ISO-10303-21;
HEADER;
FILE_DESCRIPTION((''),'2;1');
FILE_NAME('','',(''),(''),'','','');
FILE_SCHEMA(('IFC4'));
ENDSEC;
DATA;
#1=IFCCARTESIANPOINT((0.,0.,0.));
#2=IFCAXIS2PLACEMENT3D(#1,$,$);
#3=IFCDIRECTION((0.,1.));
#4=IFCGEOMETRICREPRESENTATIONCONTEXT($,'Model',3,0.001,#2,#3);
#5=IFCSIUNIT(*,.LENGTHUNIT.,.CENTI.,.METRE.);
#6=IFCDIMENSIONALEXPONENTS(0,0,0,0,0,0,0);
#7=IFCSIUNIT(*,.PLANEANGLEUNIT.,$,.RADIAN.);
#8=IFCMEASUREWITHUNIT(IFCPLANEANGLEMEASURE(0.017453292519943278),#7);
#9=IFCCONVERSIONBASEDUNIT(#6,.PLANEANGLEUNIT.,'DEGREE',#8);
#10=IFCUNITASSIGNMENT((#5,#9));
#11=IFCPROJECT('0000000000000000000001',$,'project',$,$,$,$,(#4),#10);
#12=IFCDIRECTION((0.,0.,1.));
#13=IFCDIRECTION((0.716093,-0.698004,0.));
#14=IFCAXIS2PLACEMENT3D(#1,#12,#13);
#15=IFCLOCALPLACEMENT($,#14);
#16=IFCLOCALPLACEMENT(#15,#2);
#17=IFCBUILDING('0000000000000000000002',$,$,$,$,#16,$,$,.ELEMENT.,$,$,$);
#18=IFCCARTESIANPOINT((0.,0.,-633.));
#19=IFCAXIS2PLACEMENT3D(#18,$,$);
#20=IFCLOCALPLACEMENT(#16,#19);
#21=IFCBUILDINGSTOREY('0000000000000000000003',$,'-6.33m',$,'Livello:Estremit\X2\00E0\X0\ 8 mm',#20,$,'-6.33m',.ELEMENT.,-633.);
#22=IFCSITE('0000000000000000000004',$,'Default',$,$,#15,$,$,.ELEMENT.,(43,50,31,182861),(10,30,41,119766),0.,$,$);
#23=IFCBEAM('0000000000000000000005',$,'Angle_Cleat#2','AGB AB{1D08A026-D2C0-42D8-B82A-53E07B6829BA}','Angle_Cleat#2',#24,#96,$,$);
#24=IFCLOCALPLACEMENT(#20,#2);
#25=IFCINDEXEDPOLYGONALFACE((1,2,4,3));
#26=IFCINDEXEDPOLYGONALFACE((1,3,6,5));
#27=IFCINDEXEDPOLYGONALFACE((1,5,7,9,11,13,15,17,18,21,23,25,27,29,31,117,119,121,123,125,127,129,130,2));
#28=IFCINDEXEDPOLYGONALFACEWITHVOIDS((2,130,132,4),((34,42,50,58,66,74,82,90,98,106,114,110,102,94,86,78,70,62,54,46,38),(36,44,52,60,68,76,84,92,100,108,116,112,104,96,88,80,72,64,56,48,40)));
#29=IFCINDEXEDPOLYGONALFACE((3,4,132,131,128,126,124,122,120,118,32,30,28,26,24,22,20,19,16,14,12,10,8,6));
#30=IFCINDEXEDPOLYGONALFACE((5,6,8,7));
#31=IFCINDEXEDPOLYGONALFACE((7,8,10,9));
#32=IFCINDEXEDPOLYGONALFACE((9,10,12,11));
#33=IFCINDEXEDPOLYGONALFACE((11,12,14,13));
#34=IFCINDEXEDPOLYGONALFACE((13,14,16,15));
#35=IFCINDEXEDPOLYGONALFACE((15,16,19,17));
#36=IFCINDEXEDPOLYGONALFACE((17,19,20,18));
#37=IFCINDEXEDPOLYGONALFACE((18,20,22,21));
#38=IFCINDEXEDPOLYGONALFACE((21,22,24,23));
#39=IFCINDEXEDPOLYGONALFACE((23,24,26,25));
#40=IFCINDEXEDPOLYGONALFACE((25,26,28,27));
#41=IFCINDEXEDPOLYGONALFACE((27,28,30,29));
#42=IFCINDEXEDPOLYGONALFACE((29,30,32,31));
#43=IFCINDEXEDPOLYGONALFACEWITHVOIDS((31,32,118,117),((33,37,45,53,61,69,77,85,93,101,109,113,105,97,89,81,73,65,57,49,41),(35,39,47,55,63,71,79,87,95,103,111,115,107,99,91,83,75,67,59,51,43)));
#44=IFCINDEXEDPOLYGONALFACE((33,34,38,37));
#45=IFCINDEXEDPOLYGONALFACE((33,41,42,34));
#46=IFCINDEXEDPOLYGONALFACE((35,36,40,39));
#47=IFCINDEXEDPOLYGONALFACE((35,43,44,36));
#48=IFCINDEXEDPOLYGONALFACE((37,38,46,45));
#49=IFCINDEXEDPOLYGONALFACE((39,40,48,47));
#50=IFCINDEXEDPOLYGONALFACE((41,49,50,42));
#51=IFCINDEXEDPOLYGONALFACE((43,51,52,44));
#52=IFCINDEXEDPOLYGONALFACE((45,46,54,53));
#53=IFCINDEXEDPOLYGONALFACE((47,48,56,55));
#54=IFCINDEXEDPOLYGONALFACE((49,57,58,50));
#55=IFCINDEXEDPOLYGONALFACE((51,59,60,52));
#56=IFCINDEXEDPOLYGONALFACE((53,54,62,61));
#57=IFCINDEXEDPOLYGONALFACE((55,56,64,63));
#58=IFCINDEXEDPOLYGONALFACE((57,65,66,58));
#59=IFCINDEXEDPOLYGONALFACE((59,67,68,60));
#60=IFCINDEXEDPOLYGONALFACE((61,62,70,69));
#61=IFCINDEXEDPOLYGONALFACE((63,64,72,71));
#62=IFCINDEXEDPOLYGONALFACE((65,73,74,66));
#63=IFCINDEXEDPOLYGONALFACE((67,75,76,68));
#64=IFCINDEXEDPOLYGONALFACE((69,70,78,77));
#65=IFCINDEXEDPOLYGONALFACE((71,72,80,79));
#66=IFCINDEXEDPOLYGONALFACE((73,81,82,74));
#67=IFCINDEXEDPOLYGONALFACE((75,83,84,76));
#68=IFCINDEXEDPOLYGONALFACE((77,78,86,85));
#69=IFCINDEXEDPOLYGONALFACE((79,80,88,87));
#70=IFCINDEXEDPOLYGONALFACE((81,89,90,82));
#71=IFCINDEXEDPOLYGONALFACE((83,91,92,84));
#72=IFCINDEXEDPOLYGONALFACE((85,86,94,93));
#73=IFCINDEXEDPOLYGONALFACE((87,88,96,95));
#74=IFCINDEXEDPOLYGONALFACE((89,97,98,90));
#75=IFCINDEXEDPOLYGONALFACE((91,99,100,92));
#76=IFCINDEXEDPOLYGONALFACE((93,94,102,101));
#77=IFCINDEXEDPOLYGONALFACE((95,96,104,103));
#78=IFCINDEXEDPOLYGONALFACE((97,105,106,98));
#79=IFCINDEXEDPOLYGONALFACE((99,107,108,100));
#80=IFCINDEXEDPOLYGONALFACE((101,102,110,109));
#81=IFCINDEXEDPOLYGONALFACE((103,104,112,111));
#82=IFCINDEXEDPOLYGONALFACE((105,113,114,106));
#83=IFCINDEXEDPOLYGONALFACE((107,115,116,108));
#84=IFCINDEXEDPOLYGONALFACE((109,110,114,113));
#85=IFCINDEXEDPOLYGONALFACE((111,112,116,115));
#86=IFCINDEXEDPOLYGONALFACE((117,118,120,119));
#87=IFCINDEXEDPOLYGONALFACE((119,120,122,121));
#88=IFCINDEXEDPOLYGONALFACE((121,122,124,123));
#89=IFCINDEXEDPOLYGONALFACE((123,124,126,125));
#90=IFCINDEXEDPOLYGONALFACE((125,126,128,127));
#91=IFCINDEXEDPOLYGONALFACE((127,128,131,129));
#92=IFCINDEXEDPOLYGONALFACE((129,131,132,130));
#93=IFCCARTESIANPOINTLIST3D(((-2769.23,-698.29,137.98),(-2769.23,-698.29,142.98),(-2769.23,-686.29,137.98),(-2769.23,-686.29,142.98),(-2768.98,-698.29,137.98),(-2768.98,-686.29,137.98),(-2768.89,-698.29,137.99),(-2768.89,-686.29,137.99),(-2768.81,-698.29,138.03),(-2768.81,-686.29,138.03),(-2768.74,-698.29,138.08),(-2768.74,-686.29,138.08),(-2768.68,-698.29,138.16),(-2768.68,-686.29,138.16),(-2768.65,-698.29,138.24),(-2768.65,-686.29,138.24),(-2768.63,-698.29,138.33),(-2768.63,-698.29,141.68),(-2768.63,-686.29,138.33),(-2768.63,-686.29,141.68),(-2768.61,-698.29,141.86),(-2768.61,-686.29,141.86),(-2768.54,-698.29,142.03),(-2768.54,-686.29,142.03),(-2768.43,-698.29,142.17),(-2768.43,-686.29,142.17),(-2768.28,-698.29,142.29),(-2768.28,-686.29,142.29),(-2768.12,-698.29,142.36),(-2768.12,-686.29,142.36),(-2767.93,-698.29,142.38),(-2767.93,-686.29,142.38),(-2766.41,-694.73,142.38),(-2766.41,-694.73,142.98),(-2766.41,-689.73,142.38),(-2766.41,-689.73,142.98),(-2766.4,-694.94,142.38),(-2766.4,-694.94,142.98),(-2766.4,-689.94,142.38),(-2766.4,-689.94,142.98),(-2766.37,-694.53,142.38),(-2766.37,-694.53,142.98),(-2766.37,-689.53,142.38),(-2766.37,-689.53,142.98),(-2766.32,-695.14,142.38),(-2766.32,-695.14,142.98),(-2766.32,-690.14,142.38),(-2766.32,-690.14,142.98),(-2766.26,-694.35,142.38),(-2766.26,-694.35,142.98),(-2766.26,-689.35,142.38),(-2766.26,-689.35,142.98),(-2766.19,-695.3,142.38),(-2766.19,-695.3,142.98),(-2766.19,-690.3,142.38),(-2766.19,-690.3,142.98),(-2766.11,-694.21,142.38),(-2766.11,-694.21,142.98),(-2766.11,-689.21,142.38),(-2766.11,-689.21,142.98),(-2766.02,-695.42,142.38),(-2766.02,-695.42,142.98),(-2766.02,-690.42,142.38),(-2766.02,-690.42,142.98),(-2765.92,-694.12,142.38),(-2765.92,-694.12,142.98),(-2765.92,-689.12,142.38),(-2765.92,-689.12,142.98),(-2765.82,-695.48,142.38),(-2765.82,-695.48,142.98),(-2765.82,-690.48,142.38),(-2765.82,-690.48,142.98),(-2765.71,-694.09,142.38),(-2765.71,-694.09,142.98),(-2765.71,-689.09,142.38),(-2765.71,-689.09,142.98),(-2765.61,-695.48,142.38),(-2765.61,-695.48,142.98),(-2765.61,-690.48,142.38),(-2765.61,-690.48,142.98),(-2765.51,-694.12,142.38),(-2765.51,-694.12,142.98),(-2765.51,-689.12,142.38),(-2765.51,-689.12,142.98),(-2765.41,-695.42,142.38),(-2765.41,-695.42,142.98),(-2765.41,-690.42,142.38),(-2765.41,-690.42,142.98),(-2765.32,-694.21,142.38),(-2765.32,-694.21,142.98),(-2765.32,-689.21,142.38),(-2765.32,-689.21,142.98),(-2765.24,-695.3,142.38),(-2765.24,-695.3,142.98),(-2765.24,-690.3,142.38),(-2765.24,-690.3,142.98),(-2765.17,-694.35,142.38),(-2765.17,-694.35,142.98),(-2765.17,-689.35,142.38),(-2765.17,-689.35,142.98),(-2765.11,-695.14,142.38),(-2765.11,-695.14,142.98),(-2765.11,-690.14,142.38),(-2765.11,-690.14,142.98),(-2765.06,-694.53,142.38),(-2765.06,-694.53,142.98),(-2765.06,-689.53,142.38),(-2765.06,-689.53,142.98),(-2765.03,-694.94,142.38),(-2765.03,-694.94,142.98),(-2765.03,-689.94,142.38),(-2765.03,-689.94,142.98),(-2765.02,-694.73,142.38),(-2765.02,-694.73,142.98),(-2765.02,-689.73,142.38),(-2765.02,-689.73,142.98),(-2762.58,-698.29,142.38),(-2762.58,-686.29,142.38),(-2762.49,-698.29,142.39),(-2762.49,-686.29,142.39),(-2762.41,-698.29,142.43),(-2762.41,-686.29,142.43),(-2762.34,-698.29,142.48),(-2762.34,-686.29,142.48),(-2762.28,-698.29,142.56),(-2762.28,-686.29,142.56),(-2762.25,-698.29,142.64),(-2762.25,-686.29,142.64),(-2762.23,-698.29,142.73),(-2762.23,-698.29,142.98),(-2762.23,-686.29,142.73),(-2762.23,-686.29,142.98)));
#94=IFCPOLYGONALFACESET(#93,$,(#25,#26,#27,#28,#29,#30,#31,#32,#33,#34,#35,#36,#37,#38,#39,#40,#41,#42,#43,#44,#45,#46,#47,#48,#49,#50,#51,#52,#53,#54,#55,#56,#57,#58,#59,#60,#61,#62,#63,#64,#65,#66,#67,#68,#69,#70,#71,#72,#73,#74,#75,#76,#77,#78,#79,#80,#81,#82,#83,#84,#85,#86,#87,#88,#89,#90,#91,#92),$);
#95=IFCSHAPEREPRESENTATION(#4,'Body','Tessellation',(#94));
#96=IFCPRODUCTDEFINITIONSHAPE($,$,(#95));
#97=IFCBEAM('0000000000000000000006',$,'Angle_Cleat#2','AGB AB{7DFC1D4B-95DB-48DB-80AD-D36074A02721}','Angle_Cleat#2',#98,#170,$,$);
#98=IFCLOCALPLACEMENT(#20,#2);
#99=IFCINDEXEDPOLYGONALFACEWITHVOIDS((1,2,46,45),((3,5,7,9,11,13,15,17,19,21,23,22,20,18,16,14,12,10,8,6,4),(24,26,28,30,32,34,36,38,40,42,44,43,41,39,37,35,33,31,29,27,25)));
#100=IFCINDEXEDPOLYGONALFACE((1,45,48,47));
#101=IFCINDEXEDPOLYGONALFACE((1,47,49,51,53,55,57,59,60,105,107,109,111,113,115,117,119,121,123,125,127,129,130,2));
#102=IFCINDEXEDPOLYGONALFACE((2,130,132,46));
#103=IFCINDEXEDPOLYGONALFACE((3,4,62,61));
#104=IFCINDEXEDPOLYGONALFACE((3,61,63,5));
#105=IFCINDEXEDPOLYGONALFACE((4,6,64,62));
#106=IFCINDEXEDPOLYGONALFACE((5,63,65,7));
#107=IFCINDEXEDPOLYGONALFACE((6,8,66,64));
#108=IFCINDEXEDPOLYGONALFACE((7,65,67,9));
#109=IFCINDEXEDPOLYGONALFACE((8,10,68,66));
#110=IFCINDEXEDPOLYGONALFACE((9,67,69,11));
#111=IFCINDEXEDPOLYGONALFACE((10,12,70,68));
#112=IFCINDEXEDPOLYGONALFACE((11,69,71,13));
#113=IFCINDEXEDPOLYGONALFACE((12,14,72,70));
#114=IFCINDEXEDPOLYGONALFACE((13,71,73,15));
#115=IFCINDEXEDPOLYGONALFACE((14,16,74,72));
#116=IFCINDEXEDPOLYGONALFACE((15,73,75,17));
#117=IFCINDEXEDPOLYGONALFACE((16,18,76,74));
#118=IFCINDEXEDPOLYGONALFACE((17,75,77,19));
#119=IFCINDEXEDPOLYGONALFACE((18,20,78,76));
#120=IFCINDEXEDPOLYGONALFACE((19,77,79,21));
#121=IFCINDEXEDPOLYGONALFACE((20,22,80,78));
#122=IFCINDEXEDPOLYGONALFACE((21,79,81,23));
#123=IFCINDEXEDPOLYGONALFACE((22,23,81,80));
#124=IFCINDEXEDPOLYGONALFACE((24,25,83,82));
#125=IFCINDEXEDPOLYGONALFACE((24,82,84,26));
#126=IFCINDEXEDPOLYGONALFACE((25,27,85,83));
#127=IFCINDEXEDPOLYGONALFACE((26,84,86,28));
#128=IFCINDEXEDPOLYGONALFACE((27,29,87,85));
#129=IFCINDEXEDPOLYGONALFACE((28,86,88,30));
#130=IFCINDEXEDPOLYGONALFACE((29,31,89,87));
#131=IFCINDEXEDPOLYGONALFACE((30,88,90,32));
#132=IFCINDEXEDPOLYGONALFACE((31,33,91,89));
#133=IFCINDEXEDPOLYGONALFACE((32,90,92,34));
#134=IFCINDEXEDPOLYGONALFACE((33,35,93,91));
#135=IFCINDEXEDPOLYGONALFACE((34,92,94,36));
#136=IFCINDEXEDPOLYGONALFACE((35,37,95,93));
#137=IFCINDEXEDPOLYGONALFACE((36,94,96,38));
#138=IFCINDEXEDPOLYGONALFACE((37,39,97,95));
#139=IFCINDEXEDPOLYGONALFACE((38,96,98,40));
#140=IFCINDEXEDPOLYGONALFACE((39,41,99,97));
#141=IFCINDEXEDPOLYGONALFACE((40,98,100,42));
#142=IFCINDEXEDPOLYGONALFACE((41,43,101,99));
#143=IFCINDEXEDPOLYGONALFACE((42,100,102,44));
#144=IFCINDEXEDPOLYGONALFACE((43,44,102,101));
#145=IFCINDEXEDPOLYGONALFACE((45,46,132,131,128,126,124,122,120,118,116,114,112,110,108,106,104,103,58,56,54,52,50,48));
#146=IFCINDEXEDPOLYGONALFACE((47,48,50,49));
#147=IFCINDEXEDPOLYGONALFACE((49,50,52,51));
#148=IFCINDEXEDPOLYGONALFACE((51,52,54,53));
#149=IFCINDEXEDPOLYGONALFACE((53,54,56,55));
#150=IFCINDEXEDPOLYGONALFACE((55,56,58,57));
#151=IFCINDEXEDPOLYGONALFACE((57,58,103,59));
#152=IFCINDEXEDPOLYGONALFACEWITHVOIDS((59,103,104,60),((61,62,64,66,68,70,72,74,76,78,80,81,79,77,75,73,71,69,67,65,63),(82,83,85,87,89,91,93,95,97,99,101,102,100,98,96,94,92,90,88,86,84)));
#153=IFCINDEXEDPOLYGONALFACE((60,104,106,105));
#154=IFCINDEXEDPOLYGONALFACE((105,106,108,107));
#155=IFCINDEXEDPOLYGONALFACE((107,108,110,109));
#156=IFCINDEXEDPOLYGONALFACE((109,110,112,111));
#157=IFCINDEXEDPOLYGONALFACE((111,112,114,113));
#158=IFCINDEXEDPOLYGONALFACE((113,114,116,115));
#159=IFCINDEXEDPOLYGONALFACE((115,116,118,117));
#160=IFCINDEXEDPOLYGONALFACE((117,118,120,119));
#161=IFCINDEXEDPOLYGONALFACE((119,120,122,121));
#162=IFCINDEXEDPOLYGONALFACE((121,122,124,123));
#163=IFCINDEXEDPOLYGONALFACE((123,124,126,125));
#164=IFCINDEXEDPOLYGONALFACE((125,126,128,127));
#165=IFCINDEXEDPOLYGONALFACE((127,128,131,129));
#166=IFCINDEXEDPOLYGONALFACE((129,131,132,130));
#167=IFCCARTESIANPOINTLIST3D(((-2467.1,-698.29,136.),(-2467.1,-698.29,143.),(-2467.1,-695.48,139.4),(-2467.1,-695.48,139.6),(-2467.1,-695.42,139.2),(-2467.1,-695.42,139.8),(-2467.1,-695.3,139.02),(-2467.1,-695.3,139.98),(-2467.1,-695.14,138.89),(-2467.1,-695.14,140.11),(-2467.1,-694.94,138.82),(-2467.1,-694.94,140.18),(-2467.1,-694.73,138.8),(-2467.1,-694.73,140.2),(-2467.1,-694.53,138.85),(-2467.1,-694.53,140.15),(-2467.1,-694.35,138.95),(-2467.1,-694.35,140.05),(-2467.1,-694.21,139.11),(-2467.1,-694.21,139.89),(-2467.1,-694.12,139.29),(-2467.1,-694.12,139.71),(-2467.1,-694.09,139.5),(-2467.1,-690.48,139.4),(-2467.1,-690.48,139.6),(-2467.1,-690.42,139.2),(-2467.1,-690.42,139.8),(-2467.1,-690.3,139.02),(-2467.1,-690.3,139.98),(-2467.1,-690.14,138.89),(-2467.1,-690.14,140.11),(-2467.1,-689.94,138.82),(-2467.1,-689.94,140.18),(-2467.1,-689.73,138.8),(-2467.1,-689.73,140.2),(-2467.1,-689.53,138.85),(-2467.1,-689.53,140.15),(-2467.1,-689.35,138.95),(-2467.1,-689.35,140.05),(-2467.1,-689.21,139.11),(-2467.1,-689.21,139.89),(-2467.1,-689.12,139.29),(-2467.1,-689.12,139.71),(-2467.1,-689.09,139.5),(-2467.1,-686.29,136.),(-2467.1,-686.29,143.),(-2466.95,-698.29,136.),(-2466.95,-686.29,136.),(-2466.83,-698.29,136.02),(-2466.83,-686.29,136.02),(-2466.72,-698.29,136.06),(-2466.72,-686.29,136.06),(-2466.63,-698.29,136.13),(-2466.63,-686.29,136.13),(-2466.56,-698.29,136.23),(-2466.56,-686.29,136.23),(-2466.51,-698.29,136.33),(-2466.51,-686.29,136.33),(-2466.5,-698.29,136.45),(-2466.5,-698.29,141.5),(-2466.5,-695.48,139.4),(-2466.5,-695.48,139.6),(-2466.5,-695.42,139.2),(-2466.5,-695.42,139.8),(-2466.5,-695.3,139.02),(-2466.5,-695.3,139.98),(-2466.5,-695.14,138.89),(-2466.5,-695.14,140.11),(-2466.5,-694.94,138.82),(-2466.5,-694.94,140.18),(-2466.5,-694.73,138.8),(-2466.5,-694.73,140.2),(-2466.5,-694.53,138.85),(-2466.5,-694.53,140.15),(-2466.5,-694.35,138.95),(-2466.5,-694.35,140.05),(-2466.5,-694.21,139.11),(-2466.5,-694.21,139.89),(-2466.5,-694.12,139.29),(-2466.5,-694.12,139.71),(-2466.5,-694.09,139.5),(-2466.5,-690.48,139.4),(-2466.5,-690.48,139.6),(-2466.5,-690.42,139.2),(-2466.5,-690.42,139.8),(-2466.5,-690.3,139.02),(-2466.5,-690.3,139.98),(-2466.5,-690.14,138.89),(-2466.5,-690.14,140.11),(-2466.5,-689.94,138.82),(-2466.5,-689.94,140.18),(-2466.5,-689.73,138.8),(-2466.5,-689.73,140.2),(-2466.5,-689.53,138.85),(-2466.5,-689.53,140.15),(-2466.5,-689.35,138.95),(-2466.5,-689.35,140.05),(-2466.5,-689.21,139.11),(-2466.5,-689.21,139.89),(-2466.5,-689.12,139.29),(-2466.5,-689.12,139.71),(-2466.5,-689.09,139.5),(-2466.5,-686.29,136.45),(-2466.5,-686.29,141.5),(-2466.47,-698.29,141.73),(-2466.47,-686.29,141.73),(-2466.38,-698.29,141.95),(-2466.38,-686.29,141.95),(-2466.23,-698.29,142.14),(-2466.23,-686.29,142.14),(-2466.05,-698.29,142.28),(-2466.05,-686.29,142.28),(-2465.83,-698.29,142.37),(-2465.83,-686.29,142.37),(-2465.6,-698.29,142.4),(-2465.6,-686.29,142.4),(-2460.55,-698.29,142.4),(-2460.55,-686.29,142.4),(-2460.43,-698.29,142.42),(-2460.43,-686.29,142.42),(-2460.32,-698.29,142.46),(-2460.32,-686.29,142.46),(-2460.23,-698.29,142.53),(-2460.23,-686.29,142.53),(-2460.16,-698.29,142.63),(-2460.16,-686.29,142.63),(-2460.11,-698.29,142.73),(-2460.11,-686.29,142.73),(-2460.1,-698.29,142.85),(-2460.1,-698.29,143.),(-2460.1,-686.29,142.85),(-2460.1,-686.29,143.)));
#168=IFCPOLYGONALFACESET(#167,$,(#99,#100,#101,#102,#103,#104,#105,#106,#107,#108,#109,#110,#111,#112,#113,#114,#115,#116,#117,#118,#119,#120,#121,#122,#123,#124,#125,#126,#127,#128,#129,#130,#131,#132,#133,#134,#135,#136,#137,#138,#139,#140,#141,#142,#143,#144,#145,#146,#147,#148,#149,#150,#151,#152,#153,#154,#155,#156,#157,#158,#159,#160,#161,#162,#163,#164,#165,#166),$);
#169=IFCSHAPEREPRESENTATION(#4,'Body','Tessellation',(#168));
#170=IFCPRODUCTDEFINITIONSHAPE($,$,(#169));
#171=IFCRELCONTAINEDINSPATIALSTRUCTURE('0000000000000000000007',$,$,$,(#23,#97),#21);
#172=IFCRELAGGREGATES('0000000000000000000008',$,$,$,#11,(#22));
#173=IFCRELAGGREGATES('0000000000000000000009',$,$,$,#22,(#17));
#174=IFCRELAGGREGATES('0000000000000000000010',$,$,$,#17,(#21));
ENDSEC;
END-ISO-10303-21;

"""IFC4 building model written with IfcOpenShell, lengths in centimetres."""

from ifc_helpers import new_model, entity, si_unit, converted_unit, direction, frame, frame_2d, origin, place, context, project, spatial, circle, l_section, extrude, element, save


model = new_model("IFC4")

# Units and contexts
model_context = context("Model", 3, precision=0.001, world=origin(), true_north=direction((0.0, 1.0)))
ifc_project = project(units=[si_unit("LENGTHUNIT", "METRE", prefix="CENTI"), converted_unit("PLANEANGLEUNIT", "DEGREE", entity("IfcPlaneAngleMeasure", 0.017453292519943278), si_unit("PLANEANGLEUNIT", "RADIAN"), dimensions=[0, 0, 0, 0, 0, 0, 0])], contexts=[model_context])

# Site, building, storey
site_placement = place(None, frame((0.0, 0.0, 0.0), z_axis=(0.0, 0.0, 1.0), x_axis=(0.716093, -0.698004, 0.0)))
site = spatial("IfcSite", under=ifc_project, at=site_placement, Name="Default", CompositionType="ELEMENT", RefLatitude=(43, 50, 31, 182861), RefLongitude=(10, 30, 41, 119766), RefElevation=0.0)
building_placement = place(site_placement, origin())
building = spatial("IfcBuilding", under=site, at=building_placement, CompositionType="ELEMENT")
storey_placement = place(building_placement, frame((0.0, 0.0, -633.0)))
storey = spatial("IfcBuildingStorey", under=building, at=storey_placement, Name="-6.33m", ObjectType="Livello:Estremità 8 mm", LongName="-6.33m", CompositionType="ELEMENT", Elevation=-633.0)

# Beam, openings
beam_1_placement = place(storey_placement, frame((-2766.98, -686.29, 141.75), z_axis=(0.0, 1.0, 0.0), x_axis=(1.0, 0.0, 0.0)))
beam_1 = element("IfcBeam", 1, at=beam_1_placement, inside=storey, Name="Angle_Cleat#2", Description="AGB AB{1D08A026-D2C0-42D8-B82A-53E07B6829BA}", ObjectType="Angle_Cleat#2", context=model_context, shape_type="SweptSolid", body=[
    extrude(l_section(Depth=5.0, Width=7.0, Thickness=0.6, FilletRadius=0.7, EdgeRadius=0.35, at=frame_2d((1.25, 1.27))), origin(), (0.0, 0.0, -1.0), 12.0),
])
opening_1_placement = place(beam_1_placement, frame((1.27, -0.6, -6.0), z_axis=(0.0, -1.0, 0.0), x_axis=(0.0, 0.0, 1.0)))
element("IfcOpeningElement", 2, at=opening_1_placement, cuts=beam_1, ObjectType="Opening", context=model_context, shape_type="SweptSolid", body=[
    extrude(circle(Radius=0.7, at=frame_2d((2.5, 0.0), x_axis=(1.0, 0.0))), origin(), (0.0, 0.0, 1.0), 0.7),
])
opening_2_placement = place(beam_1_placement, frame((1.27, -0.6, -6.0), z_axis=(0.0, -1.0, 0.0), x_axis=(0.0, 0.0, 1.0)))
element("IfcOpeningElement", 3, at=opening_2_placement, cuts=beam_1, ObjectType="Opening", context=model_context, shape_type="SweptSolid", body=[
    extrude(circle(Radius=0.7, at=frame_2d((-2.5, 0.0), x_axis=(1.0, 0.0))), origin(), (0.0, 0.0, 1.0), 0.7),
])

# Beam, openings
beam_2_placement = place(storey_placement, frame((-2465.17, -686.29, 141.07), z_axis=(0.0, 1.0, 0.0), x_axis=(1.0, 0.0, 0.0)))
beam_2 = element("IfcBeam", 4, at=beam_2_placement, inside=storey, Name="Angle_Cleat#2", Description="AGB AB{7DFC1D4B-95DB-48DB-80AD-D36074A02721}", ObjectType="Angle_Cleat#2", context=model_context, shape_type="SweptSolid", body=[
    extrude(l_section(Depth=7.0, Width=7.0, Thickness=0.6, FilletRadius=0.9, EdgeRadius=0.45, at=frame_2d((1.57, 1.57))), origin(), (0.0, 0.0, -1.0), 12.0),
])
opening_3_placement = place(beam_2_placement, frame((-1.98, 1.57, -6.0), z_axis=(1.0, 0.0, 0.0), x_axis=(0.0, 0.0, 1.0)))
element("IfcOpeningElement", 5, at=opening_3_placement, cuts=beam_2, ObjectType="Opening", context=model_context, shape_type="SweptSolid", body=[
    extrude(circle(Radius=0.7, at=frame_2d((2.5, 0.0), x_axis=(1.0, 0.0))), origin(), (0.0, 0.0, 1.0), 0.7),
])
opening_4_placement = place(beam_2_placement, frame((-1.98, 1.57, -6.0), z_axis=(1.0, 0.0, 0.0), x_axis=(0.0, 0.0, 1.0)))
element("IfcOpeningElement", 6, at=opening_4_placement, cuts=beam_2, ObjectType="Opening", context=model_context, shape_type="SweptSolid", body=[
    extrude(circle(Radius=0.7, at=frame_2d((-2.5, 0.0), x_axis=(1.0, 0.0))), origin(), (0.0, 0.0, 1.0), 0.7),
])

save(model, "model.ifc")
